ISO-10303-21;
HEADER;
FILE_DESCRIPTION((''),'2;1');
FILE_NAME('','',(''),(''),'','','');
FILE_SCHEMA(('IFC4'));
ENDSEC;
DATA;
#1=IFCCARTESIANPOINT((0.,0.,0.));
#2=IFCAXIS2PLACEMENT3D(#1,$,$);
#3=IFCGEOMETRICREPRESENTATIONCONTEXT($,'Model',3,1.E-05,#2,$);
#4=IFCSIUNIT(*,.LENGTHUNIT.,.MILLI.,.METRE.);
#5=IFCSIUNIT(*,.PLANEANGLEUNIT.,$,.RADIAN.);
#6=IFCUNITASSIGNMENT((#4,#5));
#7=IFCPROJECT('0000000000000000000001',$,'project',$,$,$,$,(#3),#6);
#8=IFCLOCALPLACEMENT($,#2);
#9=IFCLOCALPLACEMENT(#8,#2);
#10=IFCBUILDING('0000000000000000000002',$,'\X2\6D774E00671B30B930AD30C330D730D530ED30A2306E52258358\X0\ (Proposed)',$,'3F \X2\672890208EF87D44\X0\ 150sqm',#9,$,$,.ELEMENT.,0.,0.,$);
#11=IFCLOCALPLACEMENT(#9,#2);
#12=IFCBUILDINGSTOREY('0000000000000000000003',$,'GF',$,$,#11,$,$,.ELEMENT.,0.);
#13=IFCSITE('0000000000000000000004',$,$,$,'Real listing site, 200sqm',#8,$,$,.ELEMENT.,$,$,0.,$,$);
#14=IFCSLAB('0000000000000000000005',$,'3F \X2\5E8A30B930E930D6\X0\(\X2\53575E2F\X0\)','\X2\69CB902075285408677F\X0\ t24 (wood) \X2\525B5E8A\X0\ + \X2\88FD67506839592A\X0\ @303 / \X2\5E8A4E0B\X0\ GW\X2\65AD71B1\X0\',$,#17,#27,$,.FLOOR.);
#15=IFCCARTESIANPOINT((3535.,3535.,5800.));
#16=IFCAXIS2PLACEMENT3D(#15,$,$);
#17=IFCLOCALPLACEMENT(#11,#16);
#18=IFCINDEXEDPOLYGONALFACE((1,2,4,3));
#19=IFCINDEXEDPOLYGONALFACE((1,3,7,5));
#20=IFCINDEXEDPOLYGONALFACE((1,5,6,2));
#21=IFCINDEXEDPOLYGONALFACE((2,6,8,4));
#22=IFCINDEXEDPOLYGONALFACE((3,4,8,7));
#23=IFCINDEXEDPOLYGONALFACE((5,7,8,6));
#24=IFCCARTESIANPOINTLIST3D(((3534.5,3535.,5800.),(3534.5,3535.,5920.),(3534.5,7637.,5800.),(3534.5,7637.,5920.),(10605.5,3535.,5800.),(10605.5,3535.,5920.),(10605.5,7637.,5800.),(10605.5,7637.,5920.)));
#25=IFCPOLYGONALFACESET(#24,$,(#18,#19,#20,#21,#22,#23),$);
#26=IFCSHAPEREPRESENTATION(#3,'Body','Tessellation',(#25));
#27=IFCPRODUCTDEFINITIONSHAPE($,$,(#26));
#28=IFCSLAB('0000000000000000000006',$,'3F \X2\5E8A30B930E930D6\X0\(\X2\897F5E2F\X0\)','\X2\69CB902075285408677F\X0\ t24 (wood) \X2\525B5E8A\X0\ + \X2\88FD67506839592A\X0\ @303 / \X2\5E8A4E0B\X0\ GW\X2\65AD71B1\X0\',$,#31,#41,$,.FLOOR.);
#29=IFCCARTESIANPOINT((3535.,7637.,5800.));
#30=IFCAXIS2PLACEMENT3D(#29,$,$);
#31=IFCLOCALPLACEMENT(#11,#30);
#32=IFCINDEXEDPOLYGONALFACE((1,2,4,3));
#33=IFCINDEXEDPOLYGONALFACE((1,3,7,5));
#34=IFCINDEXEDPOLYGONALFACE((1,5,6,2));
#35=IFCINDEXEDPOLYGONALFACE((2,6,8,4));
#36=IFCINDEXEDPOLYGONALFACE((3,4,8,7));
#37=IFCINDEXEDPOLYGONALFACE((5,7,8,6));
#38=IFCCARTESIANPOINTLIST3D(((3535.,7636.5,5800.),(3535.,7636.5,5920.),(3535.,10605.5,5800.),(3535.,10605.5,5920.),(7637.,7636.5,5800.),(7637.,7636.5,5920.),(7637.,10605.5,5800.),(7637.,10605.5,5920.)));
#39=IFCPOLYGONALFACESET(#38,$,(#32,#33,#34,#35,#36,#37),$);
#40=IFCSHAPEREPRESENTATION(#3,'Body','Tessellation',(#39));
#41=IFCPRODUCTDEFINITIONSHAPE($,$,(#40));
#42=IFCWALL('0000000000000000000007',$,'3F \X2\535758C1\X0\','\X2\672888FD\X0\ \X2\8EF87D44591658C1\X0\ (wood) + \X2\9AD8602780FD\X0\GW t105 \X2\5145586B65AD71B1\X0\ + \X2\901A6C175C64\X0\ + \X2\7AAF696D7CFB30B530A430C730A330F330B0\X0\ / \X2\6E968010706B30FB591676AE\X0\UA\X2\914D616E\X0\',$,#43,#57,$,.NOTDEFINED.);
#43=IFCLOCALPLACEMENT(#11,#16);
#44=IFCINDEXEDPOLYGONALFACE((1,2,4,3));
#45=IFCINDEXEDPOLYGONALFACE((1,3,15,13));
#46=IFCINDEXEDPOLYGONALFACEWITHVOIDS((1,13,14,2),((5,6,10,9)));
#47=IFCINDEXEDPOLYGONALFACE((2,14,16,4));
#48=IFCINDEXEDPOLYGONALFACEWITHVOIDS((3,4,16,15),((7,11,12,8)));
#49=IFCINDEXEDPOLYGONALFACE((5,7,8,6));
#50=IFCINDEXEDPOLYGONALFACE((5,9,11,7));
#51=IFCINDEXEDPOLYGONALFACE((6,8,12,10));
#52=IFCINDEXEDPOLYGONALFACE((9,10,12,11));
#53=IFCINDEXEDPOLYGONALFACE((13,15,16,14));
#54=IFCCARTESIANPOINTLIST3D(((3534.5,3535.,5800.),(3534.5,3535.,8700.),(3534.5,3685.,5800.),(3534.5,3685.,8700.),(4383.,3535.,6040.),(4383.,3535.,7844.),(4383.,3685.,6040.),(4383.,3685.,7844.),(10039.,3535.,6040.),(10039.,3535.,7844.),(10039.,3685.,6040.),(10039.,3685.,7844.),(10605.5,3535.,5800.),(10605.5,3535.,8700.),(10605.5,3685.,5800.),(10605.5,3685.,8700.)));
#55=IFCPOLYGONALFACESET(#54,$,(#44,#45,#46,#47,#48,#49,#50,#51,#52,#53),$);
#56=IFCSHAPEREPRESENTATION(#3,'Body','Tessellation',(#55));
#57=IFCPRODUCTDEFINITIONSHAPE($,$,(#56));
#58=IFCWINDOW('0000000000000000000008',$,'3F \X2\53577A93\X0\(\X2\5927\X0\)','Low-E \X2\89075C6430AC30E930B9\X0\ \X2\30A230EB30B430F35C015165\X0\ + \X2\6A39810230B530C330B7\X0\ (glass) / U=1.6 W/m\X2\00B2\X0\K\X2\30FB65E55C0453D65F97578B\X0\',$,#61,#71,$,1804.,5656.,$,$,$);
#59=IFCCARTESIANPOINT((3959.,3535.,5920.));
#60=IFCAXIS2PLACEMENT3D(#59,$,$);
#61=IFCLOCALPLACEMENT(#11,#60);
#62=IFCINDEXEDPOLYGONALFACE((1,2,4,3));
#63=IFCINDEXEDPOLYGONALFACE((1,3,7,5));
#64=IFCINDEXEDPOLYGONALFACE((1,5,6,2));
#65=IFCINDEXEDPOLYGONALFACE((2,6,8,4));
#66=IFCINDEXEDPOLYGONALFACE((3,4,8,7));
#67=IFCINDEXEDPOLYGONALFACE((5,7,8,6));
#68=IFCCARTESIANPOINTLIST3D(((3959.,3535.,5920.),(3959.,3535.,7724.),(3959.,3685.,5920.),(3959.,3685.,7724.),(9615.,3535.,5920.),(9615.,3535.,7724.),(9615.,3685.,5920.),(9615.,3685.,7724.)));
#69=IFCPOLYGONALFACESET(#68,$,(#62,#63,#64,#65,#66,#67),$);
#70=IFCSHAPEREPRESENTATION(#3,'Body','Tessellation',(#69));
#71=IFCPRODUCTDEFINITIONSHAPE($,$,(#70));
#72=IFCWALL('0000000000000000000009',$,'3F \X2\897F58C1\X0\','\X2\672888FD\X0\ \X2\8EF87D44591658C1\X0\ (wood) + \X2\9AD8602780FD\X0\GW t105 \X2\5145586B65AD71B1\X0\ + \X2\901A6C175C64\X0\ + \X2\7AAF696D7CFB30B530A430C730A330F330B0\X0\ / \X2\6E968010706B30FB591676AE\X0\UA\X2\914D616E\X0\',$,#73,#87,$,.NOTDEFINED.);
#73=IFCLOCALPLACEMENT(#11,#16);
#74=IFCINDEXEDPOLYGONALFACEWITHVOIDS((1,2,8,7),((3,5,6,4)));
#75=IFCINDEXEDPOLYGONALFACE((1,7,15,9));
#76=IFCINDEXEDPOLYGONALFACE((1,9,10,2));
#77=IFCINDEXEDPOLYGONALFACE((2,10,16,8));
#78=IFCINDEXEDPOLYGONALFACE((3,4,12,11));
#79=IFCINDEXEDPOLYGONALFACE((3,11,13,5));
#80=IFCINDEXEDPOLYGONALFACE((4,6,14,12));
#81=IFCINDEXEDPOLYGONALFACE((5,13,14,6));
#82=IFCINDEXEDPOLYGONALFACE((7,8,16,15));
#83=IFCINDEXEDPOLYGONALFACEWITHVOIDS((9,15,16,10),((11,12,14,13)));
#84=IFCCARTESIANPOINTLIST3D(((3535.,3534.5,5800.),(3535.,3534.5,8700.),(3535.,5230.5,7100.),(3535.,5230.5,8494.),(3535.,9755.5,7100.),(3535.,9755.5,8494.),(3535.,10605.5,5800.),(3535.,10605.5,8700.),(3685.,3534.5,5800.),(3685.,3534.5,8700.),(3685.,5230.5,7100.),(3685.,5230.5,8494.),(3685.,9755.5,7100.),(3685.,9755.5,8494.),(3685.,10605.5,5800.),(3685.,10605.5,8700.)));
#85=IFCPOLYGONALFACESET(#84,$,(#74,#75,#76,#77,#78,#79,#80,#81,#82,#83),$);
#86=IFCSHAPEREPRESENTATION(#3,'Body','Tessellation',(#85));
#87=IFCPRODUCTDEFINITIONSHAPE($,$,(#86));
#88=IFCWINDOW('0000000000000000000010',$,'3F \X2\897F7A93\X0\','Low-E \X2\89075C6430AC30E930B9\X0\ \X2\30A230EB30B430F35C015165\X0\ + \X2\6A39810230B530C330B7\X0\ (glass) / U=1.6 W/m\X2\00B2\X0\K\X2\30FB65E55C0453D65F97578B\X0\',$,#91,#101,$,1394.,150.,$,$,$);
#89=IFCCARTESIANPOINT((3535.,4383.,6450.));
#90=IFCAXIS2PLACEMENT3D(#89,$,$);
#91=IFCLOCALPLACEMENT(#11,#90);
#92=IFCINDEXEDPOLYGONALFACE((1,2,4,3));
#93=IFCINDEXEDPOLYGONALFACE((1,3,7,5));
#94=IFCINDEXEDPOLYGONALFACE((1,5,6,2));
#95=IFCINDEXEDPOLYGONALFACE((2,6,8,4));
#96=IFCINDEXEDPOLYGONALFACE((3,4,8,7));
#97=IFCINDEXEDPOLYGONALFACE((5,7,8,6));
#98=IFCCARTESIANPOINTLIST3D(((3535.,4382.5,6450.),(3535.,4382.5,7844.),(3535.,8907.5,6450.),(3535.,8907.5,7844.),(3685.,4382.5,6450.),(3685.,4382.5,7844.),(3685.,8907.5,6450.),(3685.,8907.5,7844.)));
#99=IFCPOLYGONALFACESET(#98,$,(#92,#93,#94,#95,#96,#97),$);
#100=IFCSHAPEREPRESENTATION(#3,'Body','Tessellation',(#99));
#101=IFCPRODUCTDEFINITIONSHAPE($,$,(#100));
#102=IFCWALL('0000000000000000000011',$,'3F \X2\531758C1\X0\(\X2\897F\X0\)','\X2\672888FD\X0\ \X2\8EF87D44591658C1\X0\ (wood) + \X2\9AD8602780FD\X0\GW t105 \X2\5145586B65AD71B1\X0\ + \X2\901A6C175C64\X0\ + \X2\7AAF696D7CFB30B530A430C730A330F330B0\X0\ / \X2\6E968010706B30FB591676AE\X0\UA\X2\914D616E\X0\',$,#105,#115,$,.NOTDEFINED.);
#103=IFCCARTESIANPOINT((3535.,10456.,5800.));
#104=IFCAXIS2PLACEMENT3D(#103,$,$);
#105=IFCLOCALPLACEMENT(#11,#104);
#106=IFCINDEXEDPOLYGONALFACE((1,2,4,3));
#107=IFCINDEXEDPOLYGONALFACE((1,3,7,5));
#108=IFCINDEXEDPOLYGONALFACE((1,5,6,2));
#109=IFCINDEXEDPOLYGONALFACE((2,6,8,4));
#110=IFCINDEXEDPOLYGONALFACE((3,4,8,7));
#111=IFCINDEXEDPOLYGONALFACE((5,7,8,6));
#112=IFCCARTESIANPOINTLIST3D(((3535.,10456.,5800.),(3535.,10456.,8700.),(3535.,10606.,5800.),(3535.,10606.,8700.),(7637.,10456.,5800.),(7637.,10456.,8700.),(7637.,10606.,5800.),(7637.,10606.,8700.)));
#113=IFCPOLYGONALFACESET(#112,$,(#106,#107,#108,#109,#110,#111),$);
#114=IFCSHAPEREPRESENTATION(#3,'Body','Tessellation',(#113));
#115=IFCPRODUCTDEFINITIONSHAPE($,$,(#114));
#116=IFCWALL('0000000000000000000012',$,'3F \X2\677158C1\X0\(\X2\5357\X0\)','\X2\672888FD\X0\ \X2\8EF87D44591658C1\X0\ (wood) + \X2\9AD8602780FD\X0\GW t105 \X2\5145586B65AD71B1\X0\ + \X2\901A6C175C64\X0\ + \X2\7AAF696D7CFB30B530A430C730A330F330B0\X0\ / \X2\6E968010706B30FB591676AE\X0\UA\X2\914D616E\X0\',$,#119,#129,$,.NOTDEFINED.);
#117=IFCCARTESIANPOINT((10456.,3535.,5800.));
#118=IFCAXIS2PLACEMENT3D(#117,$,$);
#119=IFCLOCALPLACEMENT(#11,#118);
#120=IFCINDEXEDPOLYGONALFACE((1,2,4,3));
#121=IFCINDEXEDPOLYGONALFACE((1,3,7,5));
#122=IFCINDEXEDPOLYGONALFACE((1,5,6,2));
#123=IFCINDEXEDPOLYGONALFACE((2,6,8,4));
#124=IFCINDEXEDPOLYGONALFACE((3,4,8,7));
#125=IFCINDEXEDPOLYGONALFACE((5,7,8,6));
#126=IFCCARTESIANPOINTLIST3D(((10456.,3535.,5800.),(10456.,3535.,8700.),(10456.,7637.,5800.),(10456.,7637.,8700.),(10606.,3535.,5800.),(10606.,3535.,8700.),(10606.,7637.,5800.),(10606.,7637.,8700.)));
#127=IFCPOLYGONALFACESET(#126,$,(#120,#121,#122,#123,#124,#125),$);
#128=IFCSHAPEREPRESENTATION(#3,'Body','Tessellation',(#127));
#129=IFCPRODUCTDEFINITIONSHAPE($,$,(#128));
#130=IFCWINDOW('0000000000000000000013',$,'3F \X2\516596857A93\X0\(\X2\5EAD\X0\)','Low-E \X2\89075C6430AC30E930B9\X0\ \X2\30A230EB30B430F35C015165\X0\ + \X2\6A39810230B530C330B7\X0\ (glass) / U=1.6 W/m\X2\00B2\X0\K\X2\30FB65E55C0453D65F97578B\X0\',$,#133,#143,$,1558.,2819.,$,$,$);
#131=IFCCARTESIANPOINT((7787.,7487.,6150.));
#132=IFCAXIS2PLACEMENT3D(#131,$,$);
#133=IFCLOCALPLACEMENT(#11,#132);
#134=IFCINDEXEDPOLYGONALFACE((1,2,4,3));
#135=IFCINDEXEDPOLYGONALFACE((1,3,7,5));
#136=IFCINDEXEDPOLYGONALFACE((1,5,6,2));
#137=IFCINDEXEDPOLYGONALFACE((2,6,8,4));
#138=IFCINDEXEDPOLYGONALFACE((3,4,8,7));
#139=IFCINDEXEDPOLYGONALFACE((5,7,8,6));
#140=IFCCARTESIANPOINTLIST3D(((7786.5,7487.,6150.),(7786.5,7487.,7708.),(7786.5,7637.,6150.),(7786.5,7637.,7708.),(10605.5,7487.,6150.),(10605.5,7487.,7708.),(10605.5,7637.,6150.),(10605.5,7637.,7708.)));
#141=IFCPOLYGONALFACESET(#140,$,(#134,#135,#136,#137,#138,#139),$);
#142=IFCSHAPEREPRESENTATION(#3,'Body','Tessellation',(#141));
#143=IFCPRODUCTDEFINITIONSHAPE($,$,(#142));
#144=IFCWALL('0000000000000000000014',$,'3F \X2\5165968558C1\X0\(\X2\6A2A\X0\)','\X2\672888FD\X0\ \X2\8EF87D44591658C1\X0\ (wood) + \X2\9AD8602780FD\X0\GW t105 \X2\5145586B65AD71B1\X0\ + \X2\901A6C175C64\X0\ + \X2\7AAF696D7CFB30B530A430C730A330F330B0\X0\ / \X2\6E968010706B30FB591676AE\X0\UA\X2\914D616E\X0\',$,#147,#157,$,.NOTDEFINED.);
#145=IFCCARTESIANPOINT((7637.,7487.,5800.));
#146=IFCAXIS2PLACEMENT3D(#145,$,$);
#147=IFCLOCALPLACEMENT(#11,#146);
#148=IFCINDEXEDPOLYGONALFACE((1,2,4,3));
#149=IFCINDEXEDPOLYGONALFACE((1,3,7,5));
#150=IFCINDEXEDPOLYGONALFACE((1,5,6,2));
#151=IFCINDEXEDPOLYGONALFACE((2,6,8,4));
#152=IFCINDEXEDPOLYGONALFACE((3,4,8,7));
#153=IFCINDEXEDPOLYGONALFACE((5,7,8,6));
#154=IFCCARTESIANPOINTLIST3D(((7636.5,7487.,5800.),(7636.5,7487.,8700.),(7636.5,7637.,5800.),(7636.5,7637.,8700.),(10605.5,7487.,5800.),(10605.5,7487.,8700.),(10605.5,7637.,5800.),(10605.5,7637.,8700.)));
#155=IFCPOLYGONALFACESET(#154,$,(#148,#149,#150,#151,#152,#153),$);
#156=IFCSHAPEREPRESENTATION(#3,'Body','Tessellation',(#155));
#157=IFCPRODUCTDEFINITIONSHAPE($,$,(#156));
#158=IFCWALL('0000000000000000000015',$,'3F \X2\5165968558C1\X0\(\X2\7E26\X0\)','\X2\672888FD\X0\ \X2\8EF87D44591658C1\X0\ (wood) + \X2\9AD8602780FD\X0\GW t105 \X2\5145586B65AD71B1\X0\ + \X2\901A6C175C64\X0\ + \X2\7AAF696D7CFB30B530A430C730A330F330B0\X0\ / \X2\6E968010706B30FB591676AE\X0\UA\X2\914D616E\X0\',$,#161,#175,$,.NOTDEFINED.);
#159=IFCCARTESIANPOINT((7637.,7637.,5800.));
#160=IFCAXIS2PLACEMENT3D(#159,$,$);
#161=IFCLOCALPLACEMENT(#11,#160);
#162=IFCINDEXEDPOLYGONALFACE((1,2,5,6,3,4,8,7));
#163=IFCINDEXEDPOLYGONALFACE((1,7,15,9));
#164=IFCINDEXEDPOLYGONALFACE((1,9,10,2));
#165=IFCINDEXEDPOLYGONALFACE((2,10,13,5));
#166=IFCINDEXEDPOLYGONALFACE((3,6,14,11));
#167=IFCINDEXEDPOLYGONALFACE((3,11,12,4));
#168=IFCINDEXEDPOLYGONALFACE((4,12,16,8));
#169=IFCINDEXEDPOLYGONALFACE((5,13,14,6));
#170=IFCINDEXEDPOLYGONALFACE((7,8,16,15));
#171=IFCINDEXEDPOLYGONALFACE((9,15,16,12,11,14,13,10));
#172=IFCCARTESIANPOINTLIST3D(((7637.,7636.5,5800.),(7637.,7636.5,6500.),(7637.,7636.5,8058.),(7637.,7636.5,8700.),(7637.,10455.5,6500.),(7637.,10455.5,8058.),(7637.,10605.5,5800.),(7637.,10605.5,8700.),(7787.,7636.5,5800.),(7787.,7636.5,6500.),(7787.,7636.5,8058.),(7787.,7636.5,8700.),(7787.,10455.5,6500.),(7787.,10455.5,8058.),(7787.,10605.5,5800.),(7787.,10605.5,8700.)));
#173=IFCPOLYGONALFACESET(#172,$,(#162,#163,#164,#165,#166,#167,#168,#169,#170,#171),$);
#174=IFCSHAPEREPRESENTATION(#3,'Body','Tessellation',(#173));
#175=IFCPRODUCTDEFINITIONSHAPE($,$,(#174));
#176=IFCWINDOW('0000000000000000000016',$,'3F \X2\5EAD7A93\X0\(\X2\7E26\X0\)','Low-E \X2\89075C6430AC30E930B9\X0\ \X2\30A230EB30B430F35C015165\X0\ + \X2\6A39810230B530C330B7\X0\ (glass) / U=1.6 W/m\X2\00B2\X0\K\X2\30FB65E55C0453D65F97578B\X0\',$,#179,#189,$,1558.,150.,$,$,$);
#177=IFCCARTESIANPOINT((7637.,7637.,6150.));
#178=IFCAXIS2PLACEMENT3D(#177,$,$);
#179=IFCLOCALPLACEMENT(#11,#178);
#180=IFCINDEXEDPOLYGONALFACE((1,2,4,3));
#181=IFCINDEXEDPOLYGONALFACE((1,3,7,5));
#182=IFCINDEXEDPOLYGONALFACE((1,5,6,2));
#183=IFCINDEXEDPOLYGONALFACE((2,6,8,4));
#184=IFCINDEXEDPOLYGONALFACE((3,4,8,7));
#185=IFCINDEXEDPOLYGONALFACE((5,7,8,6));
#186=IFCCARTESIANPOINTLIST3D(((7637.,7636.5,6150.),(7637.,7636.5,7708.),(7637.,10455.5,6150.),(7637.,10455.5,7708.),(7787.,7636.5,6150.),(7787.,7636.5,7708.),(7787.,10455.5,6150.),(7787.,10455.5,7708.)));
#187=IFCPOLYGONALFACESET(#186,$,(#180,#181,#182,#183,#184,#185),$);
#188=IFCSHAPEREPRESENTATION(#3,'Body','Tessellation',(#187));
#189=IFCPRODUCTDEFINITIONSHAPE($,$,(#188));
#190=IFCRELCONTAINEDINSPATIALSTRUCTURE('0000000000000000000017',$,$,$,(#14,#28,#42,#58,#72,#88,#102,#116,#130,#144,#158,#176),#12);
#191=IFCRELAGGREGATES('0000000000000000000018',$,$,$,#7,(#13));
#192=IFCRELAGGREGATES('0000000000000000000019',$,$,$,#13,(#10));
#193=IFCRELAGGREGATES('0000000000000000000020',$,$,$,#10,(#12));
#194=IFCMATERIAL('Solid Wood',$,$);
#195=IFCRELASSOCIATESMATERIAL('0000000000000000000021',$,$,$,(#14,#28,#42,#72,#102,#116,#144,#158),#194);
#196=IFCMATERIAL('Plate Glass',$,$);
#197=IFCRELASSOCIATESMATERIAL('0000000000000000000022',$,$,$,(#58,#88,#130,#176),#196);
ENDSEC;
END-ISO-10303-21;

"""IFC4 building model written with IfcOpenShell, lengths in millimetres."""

from ifc_helpers import new_model, si_unit, frame, frame_2d, origin, place, context, project, spatial, rectangle, extrude, material, element, fill, save


model = new_model("IFC4")

# Units and contexts
model_context = context("Model", 3, precision=1e-05, world=origin())
ifc_project = project(units=[si_unit("LENGTHUNIT", "METRE", prefix="MILLI"), si_unit("PLANEANGLEUNIT", "RADIAN")], contexts=[model_context])

# Site, building, storey
site_placement = place(None, origin())
site = spatial("IfcSite", under=ifc_project, at=site_placement, ObjectType="Real listing site, 200sqm", CompositionType="ELEMENT", RefElevation=0.0)
building_placement = place(site_placement, origin())
building = spatial("IfcBuilding", under=site, at=building_placement, Name="海一望スキップフロアの別荘 (Proposed)", ObjectType="3F 木造軸組 150sqm", CompositionType="ELEMENT", ElevationOfRefHeight=0.0, ElevationOfTerrain=0.0)
storey_placement = place(building_placement, origin())
storey = spatial("IfcBuildingStorey", under=building, at=storey_placement, Name="GF", CompositionType="ELEMENT", Elevation=0.0)

# Slabs
ifc_material_1 = material(Name="Solid Wood")
slab_1_placement = place(storey_placement, frame((3535.0, 3535.0, 5800.0)))
element("IfcSlab", 1, at=slab_1_placement, inside=storey, material=ifc_material_1, Name="3F 床スラブ(南帯)", Description="構造用合板 t24 (wood) 剛床 + 製材根太 @303 / 床下 GW断熱", PredefinedType="FLOOR", context=model_context, shape_type="SweptSolid", body=[
    extrude(rectangle(XDim=7071.0, YDim=4102.0, at=frame_2d((3535.0, 2051.0))), frame((3535.0, 3535.0, 5800.0)), (0.0, 0.0, 1.0), 120.0),
])
slab_2_placement = place(storey_placement, frame((3535.0, 7637.0, 5800.0)))
element("IfcSlab", 2, at=slab_2_placement, inside=storey, material=ifc_material_1, Name="3F 床スラブ(西帯)", Description="構造用合板 t24 (wood) 剛床 + 製材根太 @303 / 床下 GW断熱", PredefinedType="FLOOR", context=model_context, shape_type="SweptSolid", body=[
    extrude(rectangle(XDim=4102.0, YDim=2969.0, at=frame_2d((2051.0, 1484.0))), frame((3535.0, 7637.0, 5800.0)), (0.0, 0.0, 1.0), 120.0),
])

# Walls, openings, windows
wall_1_placement = place(storey_placement, frame((3535.0, 3535.0, 5800.0)))
wall_1 = element("IfcWall", 3, at=wall_1_placement, inside=storey, material=ifc_material_1, Name="3F 南壁", Description="木製 軸組外壁 (wood) + 高性能GW t105 充填断熱 + 通気層 + 窯業系サイディング / 準耐火・外皮UA配慮", PredefinedType="NOTDEFINED", context=model_context, shape_type="SweptSolid", body=[
    extrude(rectangle(XDim=7071.0, YDim=150.0, at=frame_2d((3535.0, 75.0))), frame((3535.0, 3535.0, 5800.0)), (0.0, 0.0, 1.0), 2900.0),
])
opening_1_placement = place(storey_placement, frame((3959.0, 3535.0, 5920.0)))
opening_1 = element("IfcOpeningElement", 4, at=opening_1_placement, cuts=wall_1, PredefinedType="NOTDEFINED", context=model_context, shape_type="SweptSolid", body=[
    extrude(rectangle(XDim=5656.0, YDim=150.0, at=frame_2d((2828.0, 75.0))), frame((3959.0, 3535.0, 5920.0)), (0.0, 0.0, 1.0), 1804.0),
])
ifc_material_2 = material(Name="Plate Glass")
window_1_placement = place(storey_placement, frame((3959.0, 3535.0, 5920.0)))
window_1 = element("IfcWindow", 5, at=window_1_placement, inside=storey, material=ifc_material_2, Name="3F 南窓(大)", Description="Low-E 複層ガラス アルゴン封入 + 樹脂サッシ (glass) / U=1.6 W/m²K・日射取得型", OverallHeight=1804.0, OverallWidth=5656.0, context=model_context, shape_type="SweptSolid", body=[
    extrude(rectangle(XDim=5656.0, YDim=150.0, at=frame_2d((2828.0, 75.0))), frame((3959.0, 3535.0, 5920.0)), (0.0, 0.0, 1.0), 1804.0),
])
fill(opening_1, window_1)
wall_2_placement = place(storey_placement, frame((3535.0, 3535.0, 5800.0)))
wall_2 = element("IfcWall", 6, at=wall_2_placement, inside=storey, material=ifc_material_1, Name="3F 西壁", Description="木製 軸組外壁 (wood) + 高性能GW t105 充填断熱 + 通気層 + 窯業系サイディング / 準耐火・外皮UA配慮", PredefinedType="NOTDEFINED", context=model_context, shape_type="SweptSolid", body=[
    extrude(rectangle(XDim=150.0, YDim=7071.0, at=frame_2d((75.0, 3535.0))), frame((3535.0, 3535.0, 5800.0)), (0.0, 0.0, 1.0), 2900.0),
])
opening_2_placement = place(storey_placement, frame((3535.0, 4383.0, 6450.0)))
opening_2 = element("IfcOpeningElement", 7, at=opening_2_placement, cuts=wall_2, PredefinedType="NOTDEFINED", context=model_context, shape_type="SweptSolid", body=[
    extrude(rectangle(XDim=150.0, YDim=4525.0, at=frame_2d((75.0, 2262.0))), frame((3535.0, 4383.0, 6450.0)), (0.0, 0.0, 1.0), 1394.0),
])
window_2_placement = place(storey_placement, frame((3535.0, 4383.0, 6450.0)))
window_2 = element("IfcWindow", 8, at=window_2_placement, inside=storey, material=ifc_material_2, Name="3F 西窓", Description="Low-E 複層ガラス アルゴン封入 + 樹脂サッシ (glass) / U=1.6 W/m²K・日射取得型", OverallHeight=1394.0, OverallWidth=150.0, context=model_context, shape_type="SweptSolid", body=[
    extrude(rectangle(XDim=150.0, YDim=4525.0, at=frame_2d((75.0, 2262.0))), frame((3535.0, 4383.0, 6450.0)), (0.0, 0.0, 1.0), 1394.0),
])
fill(opening_2, window_2)

# Wall
wall_3_placement = place(storey_placement, frame((3535.0, 10456.0, 5800.0)))
element("IfcWall", 9, at=wall_3_placement, inside=storey, material=ifc_material_1, Name="3F 北壁(西)", Description="木製 軸組外壁 (wood) + 高性能GW t105 充填断熱 + 通気層 + 窯業系サイディング / 準耐火・外皮UA配慮", PredefinedType="NOTDEFINED", context=model_context, shape_type="SweptSolid", body=[
    extrude(rectangle(XDim=4102.0, YDim=150.0, at=frame_2d((2051.0, 75.0))), frame((3535.0, 10456.0, 5800.0)), (0.0, 0.0, 1.0), 2900.0),
])

# Wall, opening, window
wall_4_placement = place(storey_placement, frame((10456.0, 3535.0, 5800.0)))
wall_4 = element("IfcWall", 10, at=wall_4_placement, inside=storey, material=ifc_material_1, Name="3F 東壁(南)", Description="木製 軸組外壁 (wood) + 高性能GW t105 充填断熱 + 通気層 + 窯業系サイディング / 準耐火・外皮UA配慮", PredefinedType="NOTDEFINED", context=model_context, shape_type="SweptSolid", body=[
    extrude(rectangle(XDim=150.0, YDim=4102.0, at=frame_2d((75.0, 2051.0))), frame((10456.0, 3535.0, 5800.0)), (0.0, 0.0, 1.0), 2900.0),
])
opening_3_placement = place(storey_placement, frame((7787.0, 7487.0, 6150.0)))
opening_3 = element("IfcOpeningElement", 11, at=opening_3_placement, cuts=wall_4, PredefinedType="NOTDEFINED", context=model_context, shape_type="SweptSolid", body=[
    extrude(rectangle(XDim=2819.0, YDim=150.0, at=frame_2d((1409.0, 75.0))), frame((7787.0, 7487.0, 6150.0)), (0.0, 0.0, 1.0), 1558.0),
])
window_3_placement = place(storey_placement, frame((7787.0, 7487.0, 6150.0)))
window_3 = element("IfcWindow", 12, at=window_3_placement, inside=storey, material=ifc_material_2, Name="3F 入隅窓(庭)", Description="Low-E 複層ガラス アルゴン封入 + 樹脂サッシ (glass) / U=1.6 W/m²K・日射取得型", OverallHeight=1558.0, OverallWidth=2819.0, context=model_context, shape_type="SweptSolid", body=[
    extrude(rectangle(XDim=2819.0, YDim=150.0, at=frame_2d((1409.0, 75.0))), frame((7787.0, 7487.0, 6150.0)), (0.0, 0.0, 1.0), 1558.0),
])
fill(opening_3, window_3)

# Wall
wall_5_placement = place(storey_placement, frame((7637.0, 7487.0, 5800.0)))
element("IfcWall", 13, at=wall_5_placement, inside=storey, material=ifc_material_1, Name="3F 入隅壁(横)", Description="木製 軸組外壁 (wood) + 高性能GW t105 充填断熱 + 通気層 + 窯業系サイディング / 準耐火・外皮UA配慮", PredefinedType="NOTDEFINED", context=model_context, shape_type="SweptSolid", body=[
    extrude(rectangle(XDim=2969.0, YDim=150.0, at=frame_2d((1484.0, 75.0))), frame((7637.0, 7487.0, 5800.0)), (0.0, 0.0, 1.0), 2900.0),
])

# Wall, opening, window
wall_6_placement = place(storey_placement, frame((7637.0, 7637.0, 5800.0)))
wall_6 = element("IfcWall", 14, at=wall_6_placement, inside=storey, material=ifc_material_1, Name="3F 入隅壁(縦)", Description="木製 軸組外壁 (wood) + 高性能GW t105 充填断熱 + 通気層 + 窯業系サイディング / 準耐火・外皮UA配慮", PredefinedType="NOTDEFINED", context=model_context, shape_type="SweptSolid", body=[
    extrude(rectangle(XDim=150.0, YDim=2969.0, at=frame_2d((75.0, 1484.0))), frame((7637.0, 7637.0, 5800.0)), (0.0, 0.0, 1.0), 2900.0),
])
opening_4_placement = place(storey_placement, frame((7637.0, 7637.0, 6150.0)))
opening_4 = element("IfcOpeningElement", 15, at=opening_4_placement, cuts=wall_6, PredefinedType="NOTDEFINED", context=model_context, shape_type="SweptSolid", body=[
    extrude(rectangle(XDim=150.0, YDim=2819.0, at=frame_2d((75.0, 1409.0))), frame((7637.0, 7637.0, 6150.0)), (0.0, 0.0, 1.0), 1558.0),
])
window_4_placement = place(storey_placement, frame((7637.0, 7637.0, 6150.0)))
window_4 = element("IfcWindow", 16, at=window_4_placement, inside=storey, material=ifc_material_2, Name="3F 庭窓(縦)", Description="Low-E 複層ガラス アルゴン封入 + 樹脂サッシ (glass) / U=1.6 W/m²K・日射取得型", OverallHeight=1558.0, OverallWidth=150.0, context=model_context, shape_type="SweptSolid", body=[
    extrude(rectangle(XDim=150.0, YDim=2819.0, at=frame_2d((75.0, 1409.0))), frame((7637.0, 7637.0, 6150.0)), (0.0, 0.0, 1.0), 1558.0),
])
fill(opening_4, window_4)

save(model, "model.ifc")
